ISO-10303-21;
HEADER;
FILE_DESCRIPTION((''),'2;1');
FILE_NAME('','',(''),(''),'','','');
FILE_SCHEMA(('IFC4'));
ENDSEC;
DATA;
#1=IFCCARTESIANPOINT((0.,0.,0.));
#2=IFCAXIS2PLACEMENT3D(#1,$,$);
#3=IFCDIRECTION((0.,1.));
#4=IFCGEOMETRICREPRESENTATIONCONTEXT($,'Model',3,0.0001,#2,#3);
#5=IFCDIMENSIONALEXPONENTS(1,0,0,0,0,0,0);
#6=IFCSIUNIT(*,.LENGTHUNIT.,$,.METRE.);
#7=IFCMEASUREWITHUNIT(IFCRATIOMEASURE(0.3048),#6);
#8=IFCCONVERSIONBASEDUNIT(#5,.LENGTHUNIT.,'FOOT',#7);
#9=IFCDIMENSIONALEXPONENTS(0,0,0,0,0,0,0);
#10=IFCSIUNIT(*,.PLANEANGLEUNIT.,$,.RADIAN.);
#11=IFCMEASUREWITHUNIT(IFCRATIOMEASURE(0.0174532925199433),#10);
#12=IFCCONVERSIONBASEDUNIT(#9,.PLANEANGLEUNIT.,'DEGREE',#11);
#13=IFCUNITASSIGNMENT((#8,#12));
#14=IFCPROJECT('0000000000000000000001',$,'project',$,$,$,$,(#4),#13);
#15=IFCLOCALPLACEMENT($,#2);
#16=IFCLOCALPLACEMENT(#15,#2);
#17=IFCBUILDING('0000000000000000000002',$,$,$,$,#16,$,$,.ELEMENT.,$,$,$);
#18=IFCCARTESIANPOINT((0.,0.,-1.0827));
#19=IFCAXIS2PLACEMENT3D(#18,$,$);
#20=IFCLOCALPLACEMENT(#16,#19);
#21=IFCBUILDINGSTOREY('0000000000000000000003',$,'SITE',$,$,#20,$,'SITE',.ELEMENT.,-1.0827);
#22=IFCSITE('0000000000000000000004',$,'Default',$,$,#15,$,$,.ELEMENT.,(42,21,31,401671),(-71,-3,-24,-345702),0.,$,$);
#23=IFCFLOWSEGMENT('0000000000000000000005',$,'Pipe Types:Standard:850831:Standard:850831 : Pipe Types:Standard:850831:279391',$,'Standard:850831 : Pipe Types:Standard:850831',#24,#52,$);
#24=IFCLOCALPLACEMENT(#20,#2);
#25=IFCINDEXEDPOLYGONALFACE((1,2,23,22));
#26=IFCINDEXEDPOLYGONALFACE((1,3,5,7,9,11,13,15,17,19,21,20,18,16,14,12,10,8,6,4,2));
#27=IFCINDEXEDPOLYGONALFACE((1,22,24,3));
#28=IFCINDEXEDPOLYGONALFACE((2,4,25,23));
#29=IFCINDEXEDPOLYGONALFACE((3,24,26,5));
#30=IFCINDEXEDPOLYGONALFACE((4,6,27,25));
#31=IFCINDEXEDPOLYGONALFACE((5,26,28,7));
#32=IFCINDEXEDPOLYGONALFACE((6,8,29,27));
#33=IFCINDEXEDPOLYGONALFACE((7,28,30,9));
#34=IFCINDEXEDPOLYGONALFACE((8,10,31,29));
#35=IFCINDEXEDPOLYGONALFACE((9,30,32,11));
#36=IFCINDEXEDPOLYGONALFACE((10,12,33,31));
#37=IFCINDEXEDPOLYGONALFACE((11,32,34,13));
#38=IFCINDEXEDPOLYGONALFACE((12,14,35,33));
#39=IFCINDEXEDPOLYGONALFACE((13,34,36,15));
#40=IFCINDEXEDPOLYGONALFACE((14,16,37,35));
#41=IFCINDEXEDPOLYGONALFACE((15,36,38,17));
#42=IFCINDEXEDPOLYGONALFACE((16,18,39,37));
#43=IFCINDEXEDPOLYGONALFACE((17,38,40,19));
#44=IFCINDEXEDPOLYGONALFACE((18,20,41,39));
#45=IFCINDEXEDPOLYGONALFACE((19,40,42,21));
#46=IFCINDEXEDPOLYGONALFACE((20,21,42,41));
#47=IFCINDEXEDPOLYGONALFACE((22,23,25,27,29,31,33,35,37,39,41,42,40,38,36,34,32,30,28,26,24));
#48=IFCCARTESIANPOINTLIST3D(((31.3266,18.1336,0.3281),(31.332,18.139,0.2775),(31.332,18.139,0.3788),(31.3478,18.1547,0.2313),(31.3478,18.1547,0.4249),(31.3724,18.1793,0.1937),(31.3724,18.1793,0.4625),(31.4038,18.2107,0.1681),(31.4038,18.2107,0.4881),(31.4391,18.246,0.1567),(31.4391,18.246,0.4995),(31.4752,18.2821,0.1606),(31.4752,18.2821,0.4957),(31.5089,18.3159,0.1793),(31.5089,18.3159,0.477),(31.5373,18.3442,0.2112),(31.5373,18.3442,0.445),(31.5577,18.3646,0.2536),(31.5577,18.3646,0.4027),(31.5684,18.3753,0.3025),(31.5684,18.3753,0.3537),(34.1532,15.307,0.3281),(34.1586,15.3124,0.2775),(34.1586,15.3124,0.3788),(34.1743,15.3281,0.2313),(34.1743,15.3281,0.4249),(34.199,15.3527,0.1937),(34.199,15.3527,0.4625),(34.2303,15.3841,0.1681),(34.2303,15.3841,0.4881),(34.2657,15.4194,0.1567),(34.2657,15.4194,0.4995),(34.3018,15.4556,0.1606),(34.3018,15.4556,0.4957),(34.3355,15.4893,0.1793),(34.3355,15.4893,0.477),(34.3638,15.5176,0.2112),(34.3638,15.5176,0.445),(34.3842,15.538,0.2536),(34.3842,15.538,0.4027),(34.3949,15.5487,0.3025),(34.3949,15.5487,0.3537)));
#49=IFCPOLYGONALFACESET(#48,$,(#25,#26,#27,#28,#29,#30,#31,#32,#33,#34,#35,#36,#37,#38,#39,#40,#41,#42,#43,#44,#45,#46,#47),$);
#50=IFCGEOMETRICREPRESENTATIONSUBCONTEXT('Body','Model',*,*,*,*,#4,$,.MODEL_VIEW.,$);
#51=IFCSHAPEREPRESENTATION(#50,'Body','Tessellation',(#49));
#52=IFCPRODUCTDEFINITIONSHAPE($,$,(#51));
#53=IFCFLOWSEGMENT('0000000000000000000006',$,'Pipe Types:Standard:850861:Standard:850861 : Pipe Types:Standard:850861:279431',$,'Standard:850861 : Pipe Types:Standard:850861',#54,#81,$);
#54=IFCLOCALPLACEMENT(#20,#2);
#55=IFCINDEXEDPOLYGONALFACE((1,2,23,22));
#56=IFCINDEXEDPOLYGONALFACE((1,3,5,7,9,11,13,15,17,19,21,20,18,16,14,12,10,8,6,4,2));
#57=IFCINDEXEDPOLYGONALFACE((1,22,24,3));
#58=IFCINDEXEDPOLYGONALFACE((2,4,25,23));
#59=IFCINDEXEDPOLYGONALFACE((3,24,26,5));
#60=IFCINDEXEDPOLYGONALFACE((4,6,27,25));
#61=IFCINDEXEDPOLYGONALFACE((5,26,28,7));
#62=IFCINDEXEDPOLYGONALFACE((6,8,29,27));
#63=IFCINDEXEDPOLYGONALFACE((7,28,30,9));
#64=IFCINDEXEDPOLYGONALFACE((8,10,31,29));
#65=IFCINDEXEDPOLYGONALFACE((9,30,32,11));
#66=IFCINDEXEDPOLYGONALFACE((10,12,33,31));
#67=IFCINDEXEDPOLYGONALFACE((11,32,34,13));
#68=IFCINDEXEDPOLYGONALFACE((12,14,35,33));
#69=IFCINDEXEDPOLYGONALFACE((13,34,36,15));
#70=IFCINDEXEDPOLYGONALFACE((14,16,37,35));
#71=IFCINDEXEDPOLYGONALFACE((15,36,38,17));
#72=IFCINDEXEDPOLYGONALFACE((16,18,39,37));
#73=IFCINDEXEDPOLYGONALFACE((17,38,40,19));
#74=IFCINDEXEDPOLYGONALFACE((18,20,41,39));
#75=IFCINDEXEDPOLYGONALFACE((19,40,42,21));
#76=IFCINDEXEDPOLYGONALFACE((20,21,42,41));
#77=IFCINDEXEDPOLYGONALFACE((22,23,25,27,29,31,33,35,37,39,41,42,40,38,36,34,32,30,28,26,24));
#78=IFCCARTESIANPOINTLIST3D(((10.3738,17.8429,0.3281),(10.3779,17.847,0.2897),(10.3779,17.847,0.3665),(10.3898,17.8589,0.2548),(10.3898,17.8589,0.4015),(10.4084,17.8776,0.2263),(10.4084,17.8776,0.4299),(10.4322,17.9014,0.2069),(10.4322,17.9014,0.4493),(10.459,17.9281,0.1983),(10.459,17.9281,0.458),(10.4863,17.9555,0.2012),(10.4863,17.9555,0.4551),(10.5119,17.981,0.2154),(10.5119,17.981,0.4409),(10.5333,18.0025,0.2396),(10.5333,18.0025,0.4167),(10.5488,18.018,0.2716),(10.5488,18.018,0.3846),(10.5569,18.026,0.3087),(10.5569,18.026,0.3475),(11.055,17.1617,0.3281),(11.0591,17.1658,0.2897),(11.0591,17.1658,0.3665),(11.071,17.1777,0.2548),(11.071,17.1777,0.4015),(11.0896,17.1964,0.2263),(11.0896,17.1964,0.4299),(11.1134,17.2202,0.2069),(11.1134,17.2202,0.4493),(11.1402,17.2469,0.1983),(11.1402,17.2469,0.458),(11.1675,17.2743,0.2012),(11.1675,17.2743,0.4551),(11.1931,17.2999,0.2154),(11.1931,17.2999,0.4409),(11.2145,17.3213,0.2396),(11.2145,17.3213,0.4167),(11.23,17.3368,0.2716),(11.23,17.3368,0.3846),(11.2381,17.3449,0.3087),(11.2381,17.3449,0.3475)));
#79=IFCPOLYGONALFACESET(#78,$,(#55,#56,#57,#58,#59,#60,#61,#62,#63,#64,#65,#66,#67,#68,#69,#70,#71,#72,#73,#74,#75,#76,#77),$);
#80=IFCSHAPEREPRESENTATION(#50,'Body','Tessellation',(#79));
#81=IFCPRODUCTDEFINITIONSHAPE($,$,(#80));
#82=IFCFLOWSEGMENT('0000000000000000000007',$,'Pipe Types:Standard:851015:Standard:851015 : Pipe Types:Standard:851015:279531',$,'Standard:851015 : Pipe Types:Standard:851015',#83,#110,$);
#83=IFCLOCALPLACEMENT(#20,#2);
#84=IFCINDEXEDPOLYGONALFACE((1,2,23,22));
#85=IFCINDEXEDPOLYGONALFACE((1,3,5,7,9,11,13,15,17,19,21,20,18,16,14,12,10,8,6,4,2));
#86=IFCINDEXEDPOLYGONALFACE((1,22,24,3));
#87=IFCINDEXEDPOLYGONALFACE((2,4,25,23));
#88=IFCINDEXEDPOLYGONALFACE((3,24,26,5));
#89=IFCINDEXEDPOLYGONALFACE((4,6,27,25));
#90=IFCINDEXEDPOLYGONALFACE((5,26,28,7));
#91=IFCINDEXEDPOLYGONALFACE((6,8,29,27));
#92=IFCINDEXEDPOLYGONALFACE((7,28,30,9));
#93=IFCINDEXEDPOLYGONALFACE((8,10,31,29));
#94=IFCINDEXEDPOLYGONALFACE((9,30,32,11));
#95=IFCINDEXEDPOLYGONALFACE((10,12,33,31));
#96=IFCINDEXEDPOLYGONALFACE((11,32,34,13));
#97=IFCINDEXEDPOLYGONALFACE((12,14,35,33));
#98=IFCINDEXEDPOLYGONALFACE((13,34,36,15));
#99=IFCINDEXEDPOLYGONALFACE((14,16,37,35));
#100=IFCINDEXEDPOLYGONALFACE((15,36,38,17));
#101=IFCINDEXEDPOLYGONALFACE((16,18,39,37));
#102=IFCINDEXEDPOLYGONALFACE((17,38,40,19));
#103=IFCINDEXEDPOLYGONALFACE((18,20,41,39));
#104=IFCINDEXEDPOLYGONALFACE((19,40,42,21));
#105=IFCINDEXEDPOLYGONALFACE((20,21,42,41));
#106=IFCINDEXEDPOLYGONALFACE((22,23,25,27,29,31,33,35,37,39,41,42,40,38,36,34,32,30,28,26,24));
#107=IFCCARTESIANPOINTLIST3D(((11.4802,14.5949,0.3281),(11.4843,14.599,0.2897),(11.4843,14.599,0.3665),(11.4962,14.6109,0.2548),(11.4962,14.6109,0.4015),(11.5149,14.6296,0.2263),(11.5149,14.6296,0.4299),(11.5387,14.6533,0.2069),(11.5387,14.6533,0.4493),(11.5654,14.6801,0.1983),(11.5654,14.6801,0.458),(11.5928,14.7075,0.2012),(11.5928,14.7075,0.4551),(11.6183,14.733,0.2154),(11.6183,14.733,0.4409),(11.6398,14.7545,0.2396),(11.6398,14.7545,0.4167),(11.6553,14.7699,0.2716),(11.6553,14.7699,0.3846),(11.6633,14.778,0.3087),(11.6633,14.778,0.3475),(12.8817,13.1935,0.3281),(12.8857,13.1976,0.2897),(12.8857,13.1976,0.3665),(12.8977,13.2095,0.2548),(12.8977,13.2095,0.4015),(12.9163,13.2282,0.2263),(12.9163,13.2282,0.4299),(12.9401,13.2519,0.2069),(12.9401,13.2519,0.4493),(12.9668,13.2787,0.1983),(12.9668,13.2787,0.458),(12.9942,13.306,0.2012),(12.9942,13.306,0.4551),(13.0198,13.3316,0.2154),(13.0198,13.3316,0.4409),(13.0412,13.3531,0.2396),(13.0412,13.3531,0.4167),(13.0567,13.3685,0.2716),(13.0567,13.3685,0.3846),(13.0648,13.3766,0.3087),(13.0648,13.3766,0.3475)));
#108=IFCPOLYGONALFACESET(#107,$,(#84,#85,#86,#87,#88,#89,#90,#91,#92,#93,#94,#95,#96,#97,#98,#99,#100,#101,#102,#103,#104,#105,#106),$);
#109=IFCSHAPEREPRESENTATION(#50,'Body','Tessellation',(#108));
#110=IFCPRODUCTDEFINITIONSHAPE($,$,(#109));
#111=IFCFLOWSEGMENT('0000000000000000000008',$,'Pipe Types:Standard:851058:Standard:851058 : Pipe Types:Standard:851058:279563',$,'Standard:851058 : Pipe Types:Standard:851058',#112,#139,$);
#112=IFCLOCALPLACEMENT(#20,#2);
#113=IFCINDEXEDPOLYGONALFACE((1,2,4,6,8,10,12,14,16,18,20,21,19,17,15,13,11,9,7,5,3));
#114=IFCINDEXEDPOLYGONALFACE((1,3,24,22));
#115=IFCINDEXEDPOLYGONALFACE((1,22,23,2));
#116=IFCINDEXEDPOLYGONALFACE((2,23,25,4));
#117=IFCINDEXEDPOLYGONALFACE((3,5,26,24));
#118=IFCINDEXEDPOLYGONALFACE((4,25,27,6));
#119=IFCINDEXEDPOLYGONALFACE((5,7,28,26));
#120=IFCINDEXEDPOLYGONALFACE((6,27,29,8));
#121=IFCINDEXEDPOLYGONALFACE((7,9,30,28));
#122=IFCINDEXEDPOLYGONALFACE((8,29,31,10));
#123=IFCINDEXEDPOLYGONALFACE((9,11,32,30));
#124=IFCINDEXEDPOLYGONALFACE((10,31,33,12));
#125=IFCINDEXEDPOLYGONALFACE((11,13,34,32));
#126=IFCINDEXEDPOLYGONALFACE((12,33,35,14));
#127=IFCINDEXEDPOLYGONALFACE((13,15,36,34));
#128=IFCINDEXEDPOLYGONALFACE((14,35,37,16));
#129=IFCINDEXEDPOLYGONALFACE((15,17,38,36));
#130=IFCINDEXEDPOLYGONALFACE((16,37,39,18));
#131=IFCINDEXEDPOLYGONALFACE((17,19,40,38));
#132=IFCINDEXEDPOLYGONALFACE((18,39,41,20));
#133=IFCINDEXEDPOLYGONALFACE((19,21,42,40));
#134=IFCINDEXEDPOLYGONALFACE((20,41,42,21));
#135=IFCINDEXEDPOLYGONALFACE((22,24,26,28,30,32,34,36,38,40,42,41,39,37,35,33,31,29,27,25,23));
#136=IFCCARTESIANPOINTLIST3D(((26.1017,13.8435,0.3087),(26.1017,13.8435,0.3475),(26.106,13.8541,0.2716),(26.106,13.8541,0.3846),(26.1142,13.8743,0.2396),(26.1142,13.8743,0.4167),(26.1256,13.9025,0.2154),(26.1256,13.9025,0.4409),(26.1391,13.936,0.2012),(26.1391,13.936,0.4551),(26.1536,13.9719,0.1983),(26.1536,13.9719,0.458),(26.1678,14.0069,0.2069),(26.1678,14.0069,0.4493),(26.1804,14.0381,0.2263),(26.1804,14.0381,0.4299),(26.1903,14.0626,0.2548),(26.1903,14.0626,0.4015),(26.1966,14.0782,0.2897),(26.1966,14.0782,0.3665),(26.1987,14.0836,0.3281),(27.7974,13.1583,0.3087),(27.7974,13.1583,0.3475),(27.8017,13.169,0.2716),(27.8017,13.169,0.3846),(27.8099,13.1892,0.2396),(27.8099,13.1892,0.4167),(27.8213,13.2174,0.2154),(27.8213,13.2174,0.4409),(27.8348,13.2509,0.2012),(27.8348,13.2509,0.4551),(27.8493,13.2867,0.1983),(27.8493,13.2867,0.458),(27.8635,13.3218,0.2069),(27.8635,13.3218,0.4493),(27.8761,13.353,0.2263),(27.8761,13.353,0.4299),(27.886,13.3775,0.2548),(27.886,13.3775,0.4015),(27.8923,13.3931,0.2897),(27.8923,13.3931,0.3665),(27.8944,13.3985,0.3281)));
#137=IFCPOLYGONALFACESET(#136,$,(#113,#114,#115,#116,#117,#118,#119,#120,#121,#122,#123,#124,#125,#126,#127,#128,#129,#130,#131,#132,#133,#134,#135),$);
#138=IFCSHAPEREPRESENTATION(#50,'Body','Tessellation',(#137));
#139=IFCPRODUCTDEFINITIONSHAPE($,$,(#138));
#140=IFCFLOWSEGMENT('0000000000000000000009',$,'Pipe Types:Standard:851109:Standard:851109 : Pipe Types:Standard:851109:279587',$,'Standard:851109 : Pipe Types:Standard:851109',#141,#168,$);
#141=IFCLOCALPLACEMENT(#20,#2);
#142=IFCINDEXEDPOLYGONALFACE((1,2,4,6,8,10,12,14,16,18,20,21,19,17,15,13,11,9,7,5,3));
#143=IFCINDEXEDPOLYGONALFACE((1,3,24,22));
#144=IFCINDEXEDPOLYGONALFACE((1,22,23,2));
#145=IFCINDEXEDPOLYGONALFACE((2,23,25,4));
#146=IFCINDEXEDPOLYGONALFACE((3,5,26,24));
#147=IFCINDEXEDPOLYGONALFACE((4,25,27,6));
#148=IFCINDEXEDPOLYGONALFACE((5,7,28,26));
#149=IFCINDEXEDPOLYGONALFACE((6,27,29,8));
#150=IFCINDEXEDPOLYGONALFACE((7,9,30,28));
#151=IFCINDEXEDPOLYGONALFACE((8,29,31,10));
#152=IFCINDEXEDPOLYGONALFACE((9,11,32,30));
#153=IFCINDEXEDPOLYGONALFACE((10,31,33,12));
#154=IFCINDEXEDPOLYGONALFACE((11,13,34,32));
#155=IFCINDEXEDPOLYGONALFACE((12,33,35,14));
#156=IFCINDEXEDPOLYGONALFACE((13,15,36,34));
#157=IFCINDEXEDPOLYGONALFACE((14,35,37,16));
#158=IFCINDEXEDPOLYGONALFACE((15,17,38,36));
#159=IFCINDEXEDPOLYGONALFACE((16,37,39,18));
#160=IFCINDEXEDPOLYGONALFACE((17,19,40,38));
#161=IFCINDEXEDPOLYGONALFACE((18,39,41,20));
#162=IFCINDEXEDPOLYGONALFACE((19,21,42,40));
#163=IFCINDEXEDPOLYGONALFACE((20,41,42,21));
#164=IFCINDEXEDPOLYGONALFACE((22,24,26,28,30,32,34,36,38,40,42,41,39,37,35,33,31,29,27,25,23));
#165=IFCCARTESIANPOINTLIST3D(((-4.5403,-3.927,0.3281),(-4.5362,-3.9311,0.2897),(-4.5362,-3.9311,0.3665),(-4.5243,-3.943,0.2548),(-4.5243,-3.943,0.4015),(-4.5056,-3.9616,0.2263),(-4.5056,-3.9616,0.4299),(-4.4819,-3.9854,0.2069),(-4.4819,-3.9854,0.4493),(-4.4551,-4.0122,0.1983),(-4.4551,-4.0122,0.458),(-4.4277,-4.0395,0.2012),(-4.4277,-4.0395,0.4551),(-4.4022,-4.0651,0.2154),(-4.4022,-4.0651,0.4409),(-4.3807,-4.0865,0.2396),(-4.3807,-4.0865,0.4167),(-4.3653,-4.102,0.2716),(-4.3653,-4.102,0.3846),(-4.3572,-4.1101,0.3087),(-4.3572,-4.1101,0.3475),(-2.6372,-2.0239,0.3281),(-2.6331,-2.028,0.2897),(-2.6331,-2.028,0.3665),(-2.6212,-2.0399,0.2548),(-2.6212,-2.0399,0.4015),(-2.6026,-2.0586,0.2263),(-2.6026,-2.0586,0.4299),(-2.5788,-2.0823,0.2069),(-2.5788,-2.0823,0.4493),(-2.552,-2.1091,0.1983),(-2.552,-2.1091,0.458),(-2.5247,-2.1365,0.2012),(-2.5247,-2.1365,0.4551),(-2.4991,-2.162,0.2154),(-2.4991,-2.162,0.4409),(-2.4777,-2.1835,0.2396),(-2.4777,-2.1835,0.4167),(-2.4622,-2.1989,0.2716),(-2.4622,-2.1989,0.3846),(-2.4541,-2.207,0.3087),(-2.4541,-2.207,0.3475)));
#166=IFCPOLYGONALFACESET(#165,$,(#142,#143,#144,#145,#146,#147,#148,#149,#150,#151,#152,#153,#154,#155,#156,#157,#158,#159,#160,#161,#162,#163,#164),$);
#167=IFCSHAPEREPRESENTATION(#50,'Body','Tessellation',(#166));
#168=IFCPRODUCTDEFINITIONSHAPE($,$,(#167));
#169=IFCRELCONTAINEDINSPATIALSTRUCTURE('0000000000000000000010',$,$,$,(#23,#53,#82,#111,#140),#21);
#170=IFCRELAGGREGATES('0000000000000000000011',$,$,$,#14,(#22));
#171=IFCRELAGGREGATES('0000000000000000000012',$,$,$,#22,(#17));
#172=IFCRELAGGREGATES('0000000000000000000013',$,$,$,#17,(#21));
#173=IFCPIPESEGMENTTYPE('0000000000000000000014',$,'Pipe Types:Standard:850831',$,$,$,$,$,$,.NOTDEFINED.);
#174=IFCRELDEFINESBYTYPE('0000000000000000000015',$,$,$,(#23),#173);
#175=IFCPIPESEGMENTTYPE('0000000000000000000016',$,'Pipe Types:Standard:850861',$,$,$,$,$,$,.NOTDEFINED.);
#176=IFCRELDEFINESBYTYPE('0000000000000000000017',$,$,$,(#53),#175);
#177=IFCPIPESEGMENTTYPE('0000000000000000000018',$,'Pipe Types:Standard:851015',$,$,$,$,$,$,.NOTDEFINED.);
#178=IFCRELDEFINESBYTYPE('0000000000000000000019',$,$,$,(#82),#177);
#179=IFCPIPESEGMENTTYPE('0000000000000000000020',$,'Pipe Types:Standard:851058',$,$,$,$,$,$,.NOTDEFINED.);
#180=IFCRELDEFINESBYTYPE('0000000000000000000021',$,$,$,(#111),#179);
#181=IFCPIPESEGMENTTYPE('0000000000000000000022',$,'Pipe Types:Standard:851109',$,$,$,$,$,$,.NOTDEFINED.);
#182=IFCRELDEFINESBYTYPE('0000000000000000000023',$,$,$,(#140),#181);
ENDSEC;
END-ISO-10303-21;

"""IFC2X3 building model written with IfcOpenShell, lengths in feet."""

from ifc_helpers import new_model, entity, si_unit, converted_unit, direction, frame, frame_2d, origin, place, context, subcontext, project, spatial, circle, extrude, source, transform, mapped, type_object, type_shapes, element, save


model = new_model("IFC2X3")

# Units and contexts
model_context = context("Model", 3, precision=0.0001, world=origin(), true_north=direction((0.0, 1.0)))
body_context = subcontext(model_context, "Body", "Model", "MODEL_VIEW")
ifc_project = project(units=[converted_unit("LENGTHUNIT", "FOOT", entity("IfcRatioMeasure", 0.3048), si_unit("LENGTHUNIT", "METRE"), dimensions=[1, 0, 0, 0, 0, 0, 0]), converted_unit("PLANEANGLEUNIT", "DEGREE", entity("IfcRatioMeasure", 0.0174532925199433), si_unit("PLANEANGLEUNIT", "RADIAN"), dimensions=[0, 0, 0, 0, 0, 0, 0])], contexts=[model_context])

# Site, building, storey
site_placement = place(None, origin())
site = spatial("IfcSite", under=ifc_project, at=site_placement, Name="Default", CompositionType="ELEMENT", RefLatitude=(42, 21, 31, 401671), RefLongitude=(-71, -3, -24, -345702), RefElevation=0.0)
building_placement = place(site_placement, origin())
building = spatial("IfcBuilding", under=site, at=building_placement, CompositionType="ELEMENT")
storey_placement = place(building_placement, frame((0.0, 0.0, -1.0827)))
storey = spatial("IfcBuildingStorey", under=building, at=storey_placement, Name="SITE", LongName="SITE", CompositionType="ELEMENT", Elevation=-1.0827)

# Flow segments
pipe_segment_type_1 = type_object("IfcPipeSegmentType", Name="Pipe Types:Standard:850831", PredefinedType="NOTDEFINED")
shared_shape_1 = source(origin(), body_context, "Body", "SweptSolid", [
    extrude(circle(Radius=0.1719, at=frame_2d((0.0, 0.0), x_axis=(1.0, 0.0))), frame((31.4482, 18.2551, -0.7546), z_axis=(0.707107, -0.707107, 0.0), x_axis=(-0.707107, -0.707107, 0.0)), (0.0, 0.0, 1.0), 3.9974),
])
type_shapes(pipe_segment_type_1, [shared_shape_1])
flow_segment_1_placement = place(storey_placement, frame((0.0, 0.0, 1.0827)))
element("IfcFlowSegment", 1, at=flow_segment_1_placement, inside=storey, type_object=pipe_segment_type_1, Name="Pipe Types:Standard:850831:Standard:850831 : Pipe Types:Standard:850831:279391", ObjectType="Standard:850831 : Pipe Types:Standard:850831", context=body_context, shape_type="MappedRepresentation", body=[
    mapped(shared_shape_1, transform((0.0, 0.0, 0.0), scale=1.0)),
])
pipe_segment_type_2 = type_object("IfcPipeSegmentType", Name="Pipe Types:Standard:850861", PredefinedType="NOTDEFINED")
shared_shape_2 = source(origin(), body_context, "Body", "SweptSolid", [
    extrude(circle(Radius=0.1302, at=frame_2d((0.0, 0.0), x_axis=(1.0, 0.0))), frame((11.147, 17.2538, -0.7546), z_axis=(-0.707107, 0.707107, 0.0), x_axis=(-0.707107, -0.707107, 0.0)), (0.0, 0.0, 1.0), 0.9633),
])
type_shapes(pipe_segment_type_2, [shared_shape_2])
flow_segment_2_placement = place(storey_placement, frame((0.0, 0.0, 1.0827)))
element("IfcFlowSegment", 2, at=flow_segment_2_placement, inside=storey, type_object=pipe_segment_type_2, Name="Pipe Types:Standard:850861:Standard:850861 : Pipe Types:Standard:850861:279431", ObjectType="Standard:850861 : Pipe Types:Standard:850861", context=body_context, shape_type="MappedRepresentation", body=[
    mapped(shared_shape_2, transform((0.0, 0.0, 0.0), scale=1.0)),
])
pipe_segment_type_3 = type_object("IfcPipeSegmentType", Name="Pipe Types:Standard:851015", PredefinedType="NOTDEFINED")
shared_shape_3 = source(origin(), body_context, "Body", "SweptSolid", [
    extrude(circle(Radius=0.1302, at=frame_2d((0.0, 0.0), x_axis=(1.0, 0.0))), frame((11.5723, 14.687, -0.7546), z_axis=(0.707107, -0.707107, 0.0), x_axis=(-0.707107, -0.707107, 0.0)), (0.0, 0.0, 1.0), 1.9819),
])
type_shapes(pipe_segment_type_3, [shared_shape_3])
flow_segment_3_placement = place(storey_placement, frame((0.0, 0.0, 1.0827)))
element("IfcFlowSegment", 3, at=flow_segment_3_placement, inside=storey, type_object=pipe_segment_type_3, Name="Pipe Types:Standard:851015:Standard:851015 : Pipe Types:Standard:851015:279531", ObjectType="Standard:851015 : Pipe Types:Standard:851015", context=body_context, shape_type="MappedRepresentation", body=[
    mapped(shared_shape_3, transform((0.0, 0.0, 0.0), scale=1.0)),
])
pipe_segment_type_4 = type_object("IfcPipeSegmentType", Name="Pipe Types:Standard:851058", PredefinedType="NOTDEFINED")
shared_shape_4 = source(origin(), body_context, "Body", "SweptSolid", [
    extrude(circle(Radius=0.1302, at=frame_2d((0.0, 0.0), x_axis=(1.0, 0.0))), frame((27.8457, 13.2777, -0.7546), z_axis=(-0.927184, 0.374607, 0.0), x_axis=(0.374607, 0.927184, 0.0)), (0.0, 0.0, 1.0), 1.8289),
])
type_shapes(pipe_segment_type_4, [shared_shape_4])
flow_segment_4_placement = place(storey_placement, frame((0.0, 0.0, 1.0827)))
element("IfcFlowSegment", 4, at=flow_segment_4_placement, inside=storey, type_object=pipe_segment_type_4, Name="Pipe Types:Standard:851058:Standard:851058 : Pipe Types:Standard:851058:279563", ObjectType="Standard:851058 : Pipe Types:Standard:851058", context=body_context, shape_type="MappedRepresentation", body=[
    mapped(shared_shape_4, transform((0.0, 0.0, 0.0), scale=1.0)),
])
pipe_segment_type_5 = type_object("IfcPipeSegmentType", Name="Pipe Types:Standard:851109", PredefinedType="NOTDEFINED")
shared_shape_5 = source(origin(), body_context, "Body", "SweptSolid", [
    extrude(circle(Radius=0.1302, at=frame_2d((0.0, 0.0), x_axis=(1.0, 0.0))), frame((-4.4482, -4.019, -0.7546), z_axis=(0.707107, 0.707107, 0.0), x_axis=(-0.707107, 0.707107, 0.0)), (0.0, 0.0, 1.0), 2.6913),
])
type_shapes(pipe_segment_type_5, [shared_shape_5])
flow_segment_5_placement = place(storey_placement, frame((0.0, 0.0, 1.0827)))
element("IfcFlowSegment", 5, at=flow_segment_5_placement, inside=storey, type_object=pipe_segment_type_5, Name="Pipe Types:Standard:851109:Standard:851109 : Pipe Types:Standard:851109:279587", ObjectType="Standard:851109 : Pipe Types:Standard:851109", context=body_context, shape_type="MappedRepresentation", body=[
    mapped(shared_shape_5, transform((0.0, 0.0, 0.0), scale=1.0)),
])

save(model, "model.ifc")
